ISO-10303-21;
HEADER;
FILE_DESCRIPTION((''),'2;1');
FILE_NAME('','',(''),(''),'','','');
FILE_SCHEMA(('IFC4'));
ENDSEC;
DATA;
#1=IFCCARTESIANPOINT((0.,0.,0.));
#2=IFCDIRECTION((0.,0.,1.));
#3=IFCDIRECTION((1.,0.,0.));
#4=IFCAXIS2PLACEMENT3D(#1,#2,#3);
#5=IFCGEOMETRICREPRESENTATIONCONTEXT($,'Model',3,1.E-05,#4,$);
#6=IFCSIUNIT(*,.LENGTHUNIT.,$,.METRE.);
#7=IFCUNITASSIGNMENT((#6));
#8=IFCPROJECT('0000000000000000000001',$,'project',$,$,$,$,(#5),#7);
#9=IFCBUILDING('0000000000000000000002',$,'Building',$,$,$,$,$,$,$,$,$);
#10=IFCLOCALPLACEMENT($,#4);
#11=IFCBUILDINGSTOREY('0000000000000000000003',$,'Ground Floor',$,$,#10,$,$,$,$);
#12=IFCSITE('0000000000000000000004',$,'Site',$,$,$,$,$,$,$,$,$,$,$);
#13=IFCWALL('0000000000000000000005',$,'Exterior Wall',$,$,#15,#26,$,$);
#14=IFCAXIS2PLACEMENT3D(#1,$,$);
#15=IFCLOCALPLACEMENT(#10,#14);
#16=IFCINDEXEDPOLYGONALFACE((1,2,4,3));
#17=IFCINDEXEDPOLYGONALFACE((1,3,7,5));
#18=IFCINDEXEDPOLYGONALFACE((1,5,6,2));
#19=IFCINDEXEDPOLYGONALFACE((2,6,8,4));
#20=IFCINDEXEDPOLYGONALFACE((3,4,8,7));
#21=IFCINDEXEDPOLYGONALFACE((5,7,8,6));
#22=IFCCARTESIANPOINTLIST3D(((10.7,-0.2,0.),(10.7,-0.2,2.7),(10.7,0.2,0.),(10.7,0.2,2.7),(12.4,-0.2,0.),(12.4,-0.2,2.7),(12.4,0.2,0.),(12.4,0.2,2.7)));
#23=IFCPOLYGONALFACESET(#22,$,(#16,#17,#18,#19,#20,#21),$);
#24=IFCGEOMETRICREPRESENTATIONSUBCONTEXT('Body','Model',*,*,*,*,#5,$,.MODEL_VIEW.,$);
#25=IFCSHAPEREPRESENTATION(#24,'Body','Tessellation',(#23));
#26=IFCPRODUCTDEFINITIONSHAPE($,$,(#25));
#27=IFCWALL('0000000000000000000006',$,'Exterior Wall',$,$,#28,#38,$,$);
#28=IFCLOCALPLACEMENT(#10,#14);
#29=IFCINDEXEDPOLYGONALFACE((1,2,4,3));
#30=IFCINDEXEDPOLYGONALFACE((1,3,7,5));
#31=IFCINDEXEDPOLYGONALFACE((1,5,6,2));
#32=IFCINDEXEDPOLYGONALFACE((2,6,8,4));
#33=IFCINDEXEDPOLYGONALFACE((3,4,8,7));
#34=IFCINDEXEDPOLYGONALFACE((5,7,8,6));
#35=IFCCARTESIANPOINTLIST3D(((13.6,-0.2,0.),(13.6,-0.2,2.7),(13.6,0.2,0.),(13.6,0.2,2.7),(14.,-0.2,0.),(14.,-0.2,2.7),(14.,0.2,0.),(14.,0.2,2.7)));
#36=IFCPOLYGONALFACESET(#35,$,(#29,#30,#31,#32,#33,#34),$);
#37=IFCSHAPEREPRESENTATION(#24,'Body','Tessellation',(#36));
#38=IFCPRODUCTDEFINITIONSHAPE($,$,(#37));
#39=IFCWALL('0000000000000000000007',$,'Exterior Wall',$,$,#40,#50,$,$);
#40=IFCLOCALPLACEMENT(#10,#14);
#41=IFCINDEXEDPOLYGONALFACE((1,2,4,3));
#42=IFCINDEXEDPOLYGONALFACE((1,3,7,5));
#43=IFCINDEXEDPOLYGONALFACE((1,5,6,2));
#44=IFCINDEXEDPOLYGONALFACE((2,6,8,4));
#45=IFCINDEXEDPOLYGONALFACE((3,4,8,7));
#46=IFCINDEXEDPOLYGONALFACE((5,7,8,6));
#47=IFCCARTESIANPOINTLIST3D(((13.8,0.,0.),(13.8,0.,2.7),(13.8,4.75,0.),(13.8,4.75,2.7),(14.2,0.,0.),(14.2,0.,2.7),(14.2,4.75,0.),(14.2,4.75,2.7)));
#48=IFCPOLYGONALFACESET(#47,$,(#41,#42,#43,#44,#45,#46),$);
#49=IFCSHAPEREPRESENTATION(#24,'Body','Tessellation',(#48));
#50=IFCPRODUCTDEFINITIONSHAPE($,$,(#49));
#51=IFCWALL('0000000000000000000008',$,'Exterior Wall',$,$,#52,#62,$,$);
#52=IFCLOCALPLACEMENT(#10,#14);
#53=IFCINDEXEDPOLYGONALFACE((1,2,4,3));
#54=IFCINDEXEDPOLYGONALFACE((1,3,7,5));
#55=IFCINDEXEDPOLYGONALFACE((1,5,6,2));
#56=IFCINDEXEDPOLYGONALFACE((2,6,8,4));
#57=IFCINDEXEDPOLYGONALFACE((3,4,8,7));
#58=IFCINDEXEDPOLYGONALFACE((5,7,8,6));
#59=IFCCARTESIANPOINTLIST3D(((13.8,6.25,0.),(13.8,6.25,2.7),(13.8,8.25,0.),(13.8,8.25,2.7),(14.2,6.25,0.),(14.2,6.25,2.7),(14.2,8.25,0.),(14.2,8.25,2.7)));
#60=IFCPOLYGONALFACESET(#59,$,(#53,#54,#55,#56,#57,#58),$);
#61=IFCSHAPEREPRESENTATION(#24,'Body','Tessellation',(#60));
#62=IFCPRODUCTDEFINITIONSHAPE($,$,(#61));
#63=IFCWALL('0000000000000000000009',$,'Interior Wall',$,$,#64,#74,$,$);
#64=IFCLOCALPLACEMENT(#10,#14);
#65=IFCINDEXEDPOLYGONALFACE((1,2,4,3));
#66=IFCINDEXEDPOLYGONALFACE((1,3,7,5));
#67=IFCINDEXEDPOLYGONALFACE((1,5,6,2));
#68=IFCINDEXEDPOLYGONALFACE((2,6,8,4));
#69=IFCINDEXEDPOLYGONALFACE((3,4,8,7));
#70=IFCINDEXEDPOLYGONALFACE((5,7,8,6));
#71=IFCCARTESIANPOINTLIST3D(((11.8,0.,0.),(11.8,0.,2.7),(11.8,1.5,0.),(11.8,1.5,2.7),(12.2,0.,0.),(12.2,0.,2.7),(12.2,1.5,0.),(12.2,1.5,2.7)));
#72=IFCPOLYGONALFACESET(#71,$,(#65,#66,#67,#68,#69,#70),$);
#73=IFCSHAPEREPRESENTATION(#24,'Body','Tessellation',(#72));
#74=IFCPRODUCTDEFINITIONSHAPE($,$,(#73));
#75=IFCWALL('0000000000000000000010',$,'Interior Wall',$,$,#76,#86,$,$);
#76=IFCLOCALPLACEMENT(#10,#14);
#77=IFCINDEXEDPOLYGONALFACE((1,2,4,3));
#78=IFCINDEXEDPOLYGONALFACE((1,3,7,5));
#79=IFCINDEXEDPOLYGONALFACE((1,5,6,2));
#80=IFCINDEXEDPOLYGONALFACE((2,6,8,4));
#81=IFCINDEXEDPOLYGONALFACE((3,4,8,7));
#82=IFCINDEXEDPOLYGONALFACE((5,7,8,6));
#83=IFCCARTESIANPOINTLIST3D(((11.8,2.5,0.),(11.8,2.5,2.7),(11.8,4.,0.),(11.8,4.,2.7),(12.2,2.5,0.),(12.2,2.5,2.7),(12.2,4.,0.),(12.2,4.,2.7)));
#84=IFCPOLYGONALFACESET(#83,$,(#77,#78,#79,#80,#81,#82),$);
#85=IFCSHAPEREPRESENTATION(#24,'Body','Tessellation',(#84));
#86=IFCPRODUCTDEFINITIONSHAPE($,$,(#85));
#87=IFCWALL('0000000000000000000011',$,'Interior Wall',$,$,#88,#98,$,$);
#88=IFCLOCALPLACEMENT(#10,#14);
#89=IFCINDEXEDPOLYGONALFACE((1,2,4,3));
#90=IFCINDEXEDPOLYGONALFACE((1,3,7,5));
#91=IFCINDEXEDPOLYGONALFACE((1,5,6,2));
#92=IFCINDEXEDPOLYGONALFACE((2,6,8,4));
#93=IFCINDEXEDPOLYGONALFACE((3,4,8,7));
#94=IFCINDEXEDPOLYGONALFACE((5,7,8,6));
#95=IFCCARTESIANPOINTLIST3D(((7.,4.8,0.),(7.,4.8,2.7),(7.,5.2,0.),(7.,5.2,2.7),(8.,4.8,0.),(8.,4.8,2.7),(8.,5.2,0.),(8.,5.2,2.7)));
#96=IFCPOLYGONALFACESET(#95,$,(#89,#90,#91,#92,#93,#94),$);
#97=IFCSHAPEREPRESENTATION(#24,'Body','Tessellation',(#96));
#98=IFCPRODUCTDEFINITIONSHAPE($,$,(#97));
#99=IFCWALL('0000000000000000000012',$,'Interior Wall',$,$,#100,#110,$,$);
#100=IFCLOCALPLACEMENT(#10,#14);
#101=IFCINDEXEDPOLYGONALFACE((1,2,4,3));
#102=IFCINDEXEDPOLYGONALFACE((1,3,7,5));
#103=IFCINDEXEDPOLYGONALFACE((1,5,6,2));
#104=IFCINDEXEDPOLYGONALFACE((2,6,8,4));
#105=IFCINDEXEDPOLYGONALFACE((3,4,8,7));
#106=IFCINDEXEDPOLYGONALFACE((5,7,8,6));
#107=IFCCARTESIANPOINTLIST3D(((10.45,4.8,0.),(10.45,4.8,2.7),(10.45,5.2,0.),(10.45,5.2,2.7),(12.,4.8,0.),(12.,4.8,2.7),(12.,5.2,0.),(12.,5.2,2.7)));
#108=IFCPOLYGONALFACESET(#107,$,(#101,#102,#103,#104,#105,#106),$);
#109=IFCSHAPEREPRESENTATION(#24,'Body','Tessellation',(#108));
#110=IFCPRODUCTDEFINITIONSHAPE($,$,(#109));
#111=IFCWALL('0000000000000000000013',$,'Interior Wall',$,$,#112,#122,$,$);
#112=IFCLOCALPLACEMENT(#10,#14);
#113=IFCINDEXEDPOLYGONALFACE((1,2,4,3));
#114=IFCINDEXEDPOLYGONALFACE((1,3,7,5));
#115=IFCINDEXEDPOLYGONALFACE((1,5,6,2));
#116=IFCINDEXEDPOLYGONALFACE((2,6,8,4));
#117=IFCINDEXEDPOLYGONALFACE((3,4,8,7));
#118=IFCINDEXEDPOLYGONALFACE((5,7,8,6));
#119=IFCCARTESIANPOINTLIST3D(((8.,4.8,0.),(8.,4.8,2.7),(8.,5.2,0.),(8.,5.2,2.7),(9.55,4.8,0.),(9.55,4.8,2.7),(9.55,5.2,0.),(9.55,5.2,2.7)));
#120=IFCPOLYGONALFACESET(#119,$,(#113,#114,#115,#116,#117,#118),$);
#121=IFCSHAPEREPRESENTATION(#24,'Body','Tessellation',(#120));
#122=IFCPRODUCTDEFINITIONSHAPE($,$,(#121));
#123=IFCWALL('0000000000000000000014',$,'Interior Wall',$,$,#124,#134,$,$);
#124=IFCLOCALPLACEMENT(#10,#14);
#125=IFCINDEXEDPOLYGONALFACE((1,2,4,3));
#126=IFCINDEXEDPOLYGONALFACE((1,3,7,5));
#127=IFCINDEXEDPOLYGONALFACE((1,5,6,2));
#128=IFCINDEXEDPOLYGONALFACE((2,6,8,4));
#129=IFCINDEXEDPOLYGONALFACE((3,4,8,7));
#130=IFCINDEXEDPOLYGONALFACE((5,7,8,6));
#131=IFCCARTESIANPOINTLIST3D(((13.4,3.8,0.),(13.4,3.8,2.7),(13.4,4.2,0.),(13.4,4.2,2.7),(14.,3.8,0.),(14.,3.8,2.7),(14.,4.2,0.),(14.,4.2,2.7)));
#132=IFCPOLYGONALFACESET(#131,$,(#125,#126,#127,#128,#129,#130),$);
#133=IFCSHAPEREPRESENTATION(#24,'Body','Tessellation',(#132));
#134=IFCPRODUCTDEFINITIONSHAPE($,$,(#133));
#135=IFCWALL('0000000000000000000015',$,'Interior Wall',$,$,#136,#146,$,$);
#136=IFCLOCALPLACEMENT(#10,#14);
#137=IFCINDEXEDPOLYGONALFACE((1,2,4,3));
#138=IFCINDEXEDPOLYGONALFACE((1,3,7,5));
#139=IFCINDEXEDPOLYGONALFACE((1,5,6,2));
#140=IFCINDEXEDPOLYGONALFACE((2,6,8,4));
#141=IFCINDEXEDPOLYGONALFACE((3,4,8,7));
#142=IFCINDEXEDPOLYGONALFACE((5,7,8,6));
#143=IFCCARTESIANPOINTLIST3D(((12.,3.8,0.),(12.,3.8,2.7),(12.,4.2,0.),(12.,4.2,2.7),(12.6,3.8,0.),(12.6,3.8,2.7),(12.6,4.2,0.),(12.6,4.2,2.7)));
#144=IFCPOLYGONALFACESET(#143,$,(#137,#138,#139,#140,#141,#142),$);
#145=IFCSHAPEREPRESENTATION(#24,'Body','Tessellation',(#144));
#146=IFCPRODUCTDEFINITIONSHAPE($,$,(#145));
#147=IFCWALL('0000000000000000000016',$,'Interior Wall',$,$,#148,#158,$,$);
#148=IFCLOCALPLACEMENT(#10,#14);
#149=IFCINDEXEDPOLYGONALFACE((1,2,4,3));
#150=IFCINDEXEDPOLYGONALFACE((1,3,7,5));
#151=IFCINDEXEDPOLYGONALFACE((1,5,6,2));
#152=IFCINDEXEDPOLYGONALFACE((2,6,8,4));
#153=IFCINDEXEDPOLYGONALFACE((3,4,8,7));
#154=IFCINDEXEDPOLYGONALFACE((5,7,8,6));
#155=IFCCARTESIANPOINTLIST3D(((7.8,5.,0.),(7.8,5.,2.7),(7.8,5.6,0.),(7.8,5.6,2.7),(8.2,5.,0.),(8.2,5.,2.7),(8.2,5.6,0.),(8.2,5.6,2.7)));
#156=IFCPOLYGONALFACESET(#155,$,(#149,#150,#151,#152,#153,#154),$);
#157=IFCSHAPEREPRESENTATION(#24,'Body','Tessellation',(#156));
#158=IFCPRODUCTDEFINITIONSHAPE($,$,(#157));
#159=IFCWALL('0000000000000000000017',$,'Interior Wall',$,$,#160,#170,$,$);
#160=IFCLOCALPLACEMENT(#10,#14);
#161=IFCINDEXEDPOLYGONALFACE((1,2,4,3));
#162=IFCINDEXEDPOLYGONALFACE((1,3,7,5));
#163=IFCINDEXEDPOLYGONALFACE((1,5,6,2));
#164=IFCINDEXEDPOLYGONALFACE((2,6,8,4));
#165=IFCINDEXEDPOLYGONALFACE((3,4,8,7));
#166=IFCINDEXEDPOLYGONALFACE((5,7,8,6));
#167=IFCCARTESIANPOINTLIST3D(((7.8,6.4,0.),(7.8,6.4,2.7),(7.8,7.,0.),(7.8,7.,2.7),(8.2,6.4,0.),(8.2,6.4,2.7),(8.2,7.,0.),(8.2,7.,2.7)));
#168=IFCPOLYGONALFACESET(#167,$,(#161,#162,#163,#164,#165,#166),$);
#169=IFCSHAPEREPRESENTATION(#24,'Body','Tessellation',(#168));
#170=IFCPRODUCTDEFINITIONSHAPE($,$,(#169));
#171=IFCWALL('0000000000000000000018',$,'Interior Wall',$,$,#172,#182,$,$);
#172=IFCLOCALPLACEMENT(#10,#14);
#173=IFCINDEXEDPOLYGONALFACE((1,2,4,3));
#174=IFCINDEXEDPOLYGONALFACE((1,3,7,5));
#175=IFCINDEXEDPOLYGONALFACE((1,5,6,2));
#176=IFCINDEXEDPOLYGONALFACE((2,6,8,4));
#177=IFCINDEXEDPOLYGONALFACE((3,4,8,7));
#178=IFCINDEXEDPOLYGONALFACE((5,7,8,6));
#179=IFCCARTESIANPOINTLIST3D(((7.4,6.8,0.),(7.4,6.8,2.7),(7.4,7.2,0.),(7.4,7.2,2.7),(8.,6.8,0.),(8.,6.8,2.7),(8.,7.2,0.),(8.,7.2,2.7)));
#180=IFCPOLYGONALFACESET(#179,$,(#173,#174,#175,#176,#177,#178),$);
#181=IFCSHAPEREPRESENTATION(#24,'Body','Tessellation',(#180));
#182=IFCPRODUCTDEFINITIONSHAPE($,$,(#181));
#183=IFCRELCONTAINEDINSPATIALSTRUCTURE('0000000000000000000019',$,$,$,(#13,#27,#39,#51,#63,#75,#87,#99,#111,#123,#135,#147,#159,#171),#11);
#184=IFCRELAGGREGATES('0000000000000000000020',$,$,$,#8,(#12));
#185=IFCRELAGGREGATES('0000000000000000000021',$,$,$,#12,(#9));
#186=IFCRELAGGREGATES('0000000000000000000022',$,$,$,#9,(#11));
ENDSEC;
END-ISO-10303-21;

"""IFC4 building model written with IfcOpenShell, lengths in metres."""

from ifc_helpers import new_model, si_unit, frame, origin_with_axes, place, context, subcontext, project, spatial, indexed_curve, outline, extrude, element, save


model = new_model("IFC4")

# Units and contexts
model_context = context("Model", 3, precision=1e-05, world=origin_with_axes())
body_context = subcontext(model_context, "Body", "Model", "MODEL_VIEW")
ifc_project = project(units=[si_unit("LENGTHUNIT", "METRE")], contexts=[model_context])

# Site, building, storey
site = spatial("IfcSite", under=ifc_project, Name="Site")
building = spatial("IfcBuilding", under=site, Name="Building")
storey_placement = place(None, origin_with_axes())
storey = spatial("IfcBuildingStorey", under=building, at=storey_placement, Name="Ground Floor")

# Walls
wall_1_placement = place(storey_placement, frame((10.7, 0.0, 0.0), z_axis=(0.0, 0.0, 1.0), x_axis=(1.0, 0.0, 0.0)))
element("IfcWall", 1, at=wall_1_placement, inside=storey, Name="Exterior Wall", context=body_context, shape_type="SweptSolid", body=[
    extrude(outline(indexed_curve([(0.0, 0.0), (0.0, 0.4), (1.7, 0.4), (1.7, 0.0), (0.0, 0.0)], self_intersect=False)), frame((0.0, -0.2, 0.0), z_axis=(0.0, 0.0, 1.0), x_axis=(1.0, 0.0, 0.0)), (0.0, 0.0, 1.0), 2.7),
])
wall_2_placement = place(storey_placement, frame((13.6, 0.0, 0.0), z_axis=(0.0, 0.0, 1.0), x_axis=(1.0, 0.0, 0.0)))
element("IfcWall", 2, at=wall_2_placement, inside=storey, Name="Exterior Wall", context=body_context, shape_type="SweptSolid", body=[
    extrude(outline(indexed_curve([(0.0, 0.0), (0.0, 0.4), (0.4, 0.4), (0.4, 0.0), (0.0, 0.0)], self_intersect=False)), frame((0.0, -0.2, 0.0), z_axis=(0.0, 0.0, 1.0), x_axis=(1.0, 0.0, 0.0)), (0.0, 0.0, 1.0), 2.7),
])
wall_3_placement = place(storey_placement, frame((14.0, 0.0, 0.0), z_axis=(0.0, 0.0, 1.0), x_axis=(0.0, 1.0, 0.0)))
element("IfcWall", 3, at=wall_3_placement, inside=storey, Name="Exterior Wall", context=body_context, shape_type="SweptSolid", body=[
    extrude(outline(indexed_curve([(0.0, 0.0), (0.0, 0.4), (4.75, 0.4), (4.75, 0.0), (0.0, 0.0)], self_intersect=False)), frame((0.0, -0.2, 0.0), z_axis=(0.0, 0.0, 1.0), x_axis=(1.0, 0.0, 0.0)), (0.0, 0.0, 1.0), 2.7),
])
wall_4_placement = place(storey_placement, frame((14.0, 6.25, 0.0), z_axis=(0.0, 0.0, 1.0), x_axis=(0.0, 1.0, 0.0)))
element("IfcWall", 4, at=wall_4_placement, inside=storey, Name="Exterior Wall", context=body_context, shape_type="SweptSolid", body=[
    extrude(outline(indexed_curve([(0.0, 0.0), (0.0, 0.4), (2.0, 0.4), (2.0, 0.0), (0.0, 0.0)], self_intersect=False)), frame((0.0, -0.2, 0.0), z_axis=(0.0, 0.0, 1.0), x_axis=(1.0, 0.0, 0.0)), (0.0, 0.0, 1.0), 2.7),
])
for number, where, z_axis, x_axis, name in (
    (5, (12.0, 0.0, 0.0), (0.0, 0.0, 1.0), (0.0, 1.0, 0.0), "Interior Wall"),
    (6, (12.0, 2.5, 0.0), (0.0, 0.0, 1.0), (0.0, 1.0, 0.0), "Interior Wall"),
):
    element("IfcWall", number, at=place(storey_placement, frame(where, z_axis=z_axis, x_axis=x_axis)), inside=storey, Name=name, context=body_context, shape_type="SweptSolid", body=[
        extrude(outline(indexed_curve([(0.0, 0.0), (0.0, 0.4), (1.5, 0.4), (1.5, 0.0), (0.0, 0.0)], self_intersect=False)), frame((0.0, -0.2, 0.0), z_axis=(0.0, 0.0, 1.0), x_axis=(1.0, 0.0, 0.0)), (0.0, 0.0, 1.0), 2.7),
    ])
wall_5_placement = place(storey_placement, frame((8.0, 5.0, 0.0), z_axis=(0.0, 0.0, 1.0), x_axis=(-1.0, 0.0, 0.0)))
element("IfcWall", 7, at=wall_5_placement, inside=storey, Name="Interior Wall", context=body_context, shape_type="SweptSolid", body=[
    extrude(outline(indexed_curve([(0.0, 0.0), (0.0, 0.4), (1.0, 0.4), (1.0, 0.0), (0.0, 0.0)], self_intersect=False)), frame((0.0, -0.2, 0.0), z_axis=(0.0, 0.0, 1.0), x_axis=(1.0, 0.0, 0.0)), (0.0, 0.0, 1.0), 2.7),
])
for number, where, z_axis, x_axis, name in (
    (8, (12.0, 5.0, 0.0), (0.0, 0.0, 1.0), (-1.0, 0.0, 0.0), "Interior Wall"),
    (9, (9.55, 5.0, 0.0), (0.0, 0.0, 1.0), (-1.0, 0.0, 0.0), "Interior Wall"),
):
    element("IfcWall", number, at=place(storey_placement, frame(where, z_axis=z_axis, x_axis=x_axis)), inside=storey, Name=name, context=body_context, shape_type="SweptSolid", body=[
        extrude(outline(indexed_curve([(0.0, 0.0), (0.0, 0.4), (1.55, 0.4), (1.55, 0.0), (0.0, 0.0)], self_intersect=False)), frame((0.0, -0.2, 0.0), z_axis=(0.0, 0.0, 1.0), x_axis=(1.0, 0.0, 0.0)), (0.0, 0.0, 1.0), 2.7),
    ])
for number, where, z_axis, x_axis, name in (
    (10, (14.0, 4.0, 0.0), (0.0, 0.0, 1.0), (-1.0, 0.0, 0.0), "Interior Wall"),
    (11, (12.6, 4.0, 0.0), (0.0, 0.0, 1.0), (-1.0, 0.0, 0.0), "Interior Wall"),
    (12, (8.0, 5.0, 0.0), (0.0, 0.0, 1.0), (0.0, 1.0, 0.0), "Interior Wall"),
    (13, (8.0, 6.4, 0.0), (0.0, 0.0, 1.0), (0.0, 1.0, 0.0), "Interior Wall"),
    (14, (8.0, 7.0, 0.0), (0.0, 0.0, 1.0), (-1.0, 0.0, 0.0), "Interior Wall"),
):
    element("IfcWall", number, at=place(storey_placement, frame(where, z_axis=z_axis, x_axis=x_axis)), inside=storey, Name=name, context=body_context, shape_type="SweptSolid", body=[
        extrude(outline(indexed_curve([(0.0, 0.0), (0.0, 0.4), (0.6, 0.4), (0.6, 0.0), (0.0, 0.0)], self_intersect=False)), frame((0.0, -0.2, 0.0), z_axis=(0.0, 0.0, 1.0), x_axis=(1.0, 0.0, 0.0)), (0.0, 0.0, 1.0), 2.7),
    ])

save(model, "model.ifc")
